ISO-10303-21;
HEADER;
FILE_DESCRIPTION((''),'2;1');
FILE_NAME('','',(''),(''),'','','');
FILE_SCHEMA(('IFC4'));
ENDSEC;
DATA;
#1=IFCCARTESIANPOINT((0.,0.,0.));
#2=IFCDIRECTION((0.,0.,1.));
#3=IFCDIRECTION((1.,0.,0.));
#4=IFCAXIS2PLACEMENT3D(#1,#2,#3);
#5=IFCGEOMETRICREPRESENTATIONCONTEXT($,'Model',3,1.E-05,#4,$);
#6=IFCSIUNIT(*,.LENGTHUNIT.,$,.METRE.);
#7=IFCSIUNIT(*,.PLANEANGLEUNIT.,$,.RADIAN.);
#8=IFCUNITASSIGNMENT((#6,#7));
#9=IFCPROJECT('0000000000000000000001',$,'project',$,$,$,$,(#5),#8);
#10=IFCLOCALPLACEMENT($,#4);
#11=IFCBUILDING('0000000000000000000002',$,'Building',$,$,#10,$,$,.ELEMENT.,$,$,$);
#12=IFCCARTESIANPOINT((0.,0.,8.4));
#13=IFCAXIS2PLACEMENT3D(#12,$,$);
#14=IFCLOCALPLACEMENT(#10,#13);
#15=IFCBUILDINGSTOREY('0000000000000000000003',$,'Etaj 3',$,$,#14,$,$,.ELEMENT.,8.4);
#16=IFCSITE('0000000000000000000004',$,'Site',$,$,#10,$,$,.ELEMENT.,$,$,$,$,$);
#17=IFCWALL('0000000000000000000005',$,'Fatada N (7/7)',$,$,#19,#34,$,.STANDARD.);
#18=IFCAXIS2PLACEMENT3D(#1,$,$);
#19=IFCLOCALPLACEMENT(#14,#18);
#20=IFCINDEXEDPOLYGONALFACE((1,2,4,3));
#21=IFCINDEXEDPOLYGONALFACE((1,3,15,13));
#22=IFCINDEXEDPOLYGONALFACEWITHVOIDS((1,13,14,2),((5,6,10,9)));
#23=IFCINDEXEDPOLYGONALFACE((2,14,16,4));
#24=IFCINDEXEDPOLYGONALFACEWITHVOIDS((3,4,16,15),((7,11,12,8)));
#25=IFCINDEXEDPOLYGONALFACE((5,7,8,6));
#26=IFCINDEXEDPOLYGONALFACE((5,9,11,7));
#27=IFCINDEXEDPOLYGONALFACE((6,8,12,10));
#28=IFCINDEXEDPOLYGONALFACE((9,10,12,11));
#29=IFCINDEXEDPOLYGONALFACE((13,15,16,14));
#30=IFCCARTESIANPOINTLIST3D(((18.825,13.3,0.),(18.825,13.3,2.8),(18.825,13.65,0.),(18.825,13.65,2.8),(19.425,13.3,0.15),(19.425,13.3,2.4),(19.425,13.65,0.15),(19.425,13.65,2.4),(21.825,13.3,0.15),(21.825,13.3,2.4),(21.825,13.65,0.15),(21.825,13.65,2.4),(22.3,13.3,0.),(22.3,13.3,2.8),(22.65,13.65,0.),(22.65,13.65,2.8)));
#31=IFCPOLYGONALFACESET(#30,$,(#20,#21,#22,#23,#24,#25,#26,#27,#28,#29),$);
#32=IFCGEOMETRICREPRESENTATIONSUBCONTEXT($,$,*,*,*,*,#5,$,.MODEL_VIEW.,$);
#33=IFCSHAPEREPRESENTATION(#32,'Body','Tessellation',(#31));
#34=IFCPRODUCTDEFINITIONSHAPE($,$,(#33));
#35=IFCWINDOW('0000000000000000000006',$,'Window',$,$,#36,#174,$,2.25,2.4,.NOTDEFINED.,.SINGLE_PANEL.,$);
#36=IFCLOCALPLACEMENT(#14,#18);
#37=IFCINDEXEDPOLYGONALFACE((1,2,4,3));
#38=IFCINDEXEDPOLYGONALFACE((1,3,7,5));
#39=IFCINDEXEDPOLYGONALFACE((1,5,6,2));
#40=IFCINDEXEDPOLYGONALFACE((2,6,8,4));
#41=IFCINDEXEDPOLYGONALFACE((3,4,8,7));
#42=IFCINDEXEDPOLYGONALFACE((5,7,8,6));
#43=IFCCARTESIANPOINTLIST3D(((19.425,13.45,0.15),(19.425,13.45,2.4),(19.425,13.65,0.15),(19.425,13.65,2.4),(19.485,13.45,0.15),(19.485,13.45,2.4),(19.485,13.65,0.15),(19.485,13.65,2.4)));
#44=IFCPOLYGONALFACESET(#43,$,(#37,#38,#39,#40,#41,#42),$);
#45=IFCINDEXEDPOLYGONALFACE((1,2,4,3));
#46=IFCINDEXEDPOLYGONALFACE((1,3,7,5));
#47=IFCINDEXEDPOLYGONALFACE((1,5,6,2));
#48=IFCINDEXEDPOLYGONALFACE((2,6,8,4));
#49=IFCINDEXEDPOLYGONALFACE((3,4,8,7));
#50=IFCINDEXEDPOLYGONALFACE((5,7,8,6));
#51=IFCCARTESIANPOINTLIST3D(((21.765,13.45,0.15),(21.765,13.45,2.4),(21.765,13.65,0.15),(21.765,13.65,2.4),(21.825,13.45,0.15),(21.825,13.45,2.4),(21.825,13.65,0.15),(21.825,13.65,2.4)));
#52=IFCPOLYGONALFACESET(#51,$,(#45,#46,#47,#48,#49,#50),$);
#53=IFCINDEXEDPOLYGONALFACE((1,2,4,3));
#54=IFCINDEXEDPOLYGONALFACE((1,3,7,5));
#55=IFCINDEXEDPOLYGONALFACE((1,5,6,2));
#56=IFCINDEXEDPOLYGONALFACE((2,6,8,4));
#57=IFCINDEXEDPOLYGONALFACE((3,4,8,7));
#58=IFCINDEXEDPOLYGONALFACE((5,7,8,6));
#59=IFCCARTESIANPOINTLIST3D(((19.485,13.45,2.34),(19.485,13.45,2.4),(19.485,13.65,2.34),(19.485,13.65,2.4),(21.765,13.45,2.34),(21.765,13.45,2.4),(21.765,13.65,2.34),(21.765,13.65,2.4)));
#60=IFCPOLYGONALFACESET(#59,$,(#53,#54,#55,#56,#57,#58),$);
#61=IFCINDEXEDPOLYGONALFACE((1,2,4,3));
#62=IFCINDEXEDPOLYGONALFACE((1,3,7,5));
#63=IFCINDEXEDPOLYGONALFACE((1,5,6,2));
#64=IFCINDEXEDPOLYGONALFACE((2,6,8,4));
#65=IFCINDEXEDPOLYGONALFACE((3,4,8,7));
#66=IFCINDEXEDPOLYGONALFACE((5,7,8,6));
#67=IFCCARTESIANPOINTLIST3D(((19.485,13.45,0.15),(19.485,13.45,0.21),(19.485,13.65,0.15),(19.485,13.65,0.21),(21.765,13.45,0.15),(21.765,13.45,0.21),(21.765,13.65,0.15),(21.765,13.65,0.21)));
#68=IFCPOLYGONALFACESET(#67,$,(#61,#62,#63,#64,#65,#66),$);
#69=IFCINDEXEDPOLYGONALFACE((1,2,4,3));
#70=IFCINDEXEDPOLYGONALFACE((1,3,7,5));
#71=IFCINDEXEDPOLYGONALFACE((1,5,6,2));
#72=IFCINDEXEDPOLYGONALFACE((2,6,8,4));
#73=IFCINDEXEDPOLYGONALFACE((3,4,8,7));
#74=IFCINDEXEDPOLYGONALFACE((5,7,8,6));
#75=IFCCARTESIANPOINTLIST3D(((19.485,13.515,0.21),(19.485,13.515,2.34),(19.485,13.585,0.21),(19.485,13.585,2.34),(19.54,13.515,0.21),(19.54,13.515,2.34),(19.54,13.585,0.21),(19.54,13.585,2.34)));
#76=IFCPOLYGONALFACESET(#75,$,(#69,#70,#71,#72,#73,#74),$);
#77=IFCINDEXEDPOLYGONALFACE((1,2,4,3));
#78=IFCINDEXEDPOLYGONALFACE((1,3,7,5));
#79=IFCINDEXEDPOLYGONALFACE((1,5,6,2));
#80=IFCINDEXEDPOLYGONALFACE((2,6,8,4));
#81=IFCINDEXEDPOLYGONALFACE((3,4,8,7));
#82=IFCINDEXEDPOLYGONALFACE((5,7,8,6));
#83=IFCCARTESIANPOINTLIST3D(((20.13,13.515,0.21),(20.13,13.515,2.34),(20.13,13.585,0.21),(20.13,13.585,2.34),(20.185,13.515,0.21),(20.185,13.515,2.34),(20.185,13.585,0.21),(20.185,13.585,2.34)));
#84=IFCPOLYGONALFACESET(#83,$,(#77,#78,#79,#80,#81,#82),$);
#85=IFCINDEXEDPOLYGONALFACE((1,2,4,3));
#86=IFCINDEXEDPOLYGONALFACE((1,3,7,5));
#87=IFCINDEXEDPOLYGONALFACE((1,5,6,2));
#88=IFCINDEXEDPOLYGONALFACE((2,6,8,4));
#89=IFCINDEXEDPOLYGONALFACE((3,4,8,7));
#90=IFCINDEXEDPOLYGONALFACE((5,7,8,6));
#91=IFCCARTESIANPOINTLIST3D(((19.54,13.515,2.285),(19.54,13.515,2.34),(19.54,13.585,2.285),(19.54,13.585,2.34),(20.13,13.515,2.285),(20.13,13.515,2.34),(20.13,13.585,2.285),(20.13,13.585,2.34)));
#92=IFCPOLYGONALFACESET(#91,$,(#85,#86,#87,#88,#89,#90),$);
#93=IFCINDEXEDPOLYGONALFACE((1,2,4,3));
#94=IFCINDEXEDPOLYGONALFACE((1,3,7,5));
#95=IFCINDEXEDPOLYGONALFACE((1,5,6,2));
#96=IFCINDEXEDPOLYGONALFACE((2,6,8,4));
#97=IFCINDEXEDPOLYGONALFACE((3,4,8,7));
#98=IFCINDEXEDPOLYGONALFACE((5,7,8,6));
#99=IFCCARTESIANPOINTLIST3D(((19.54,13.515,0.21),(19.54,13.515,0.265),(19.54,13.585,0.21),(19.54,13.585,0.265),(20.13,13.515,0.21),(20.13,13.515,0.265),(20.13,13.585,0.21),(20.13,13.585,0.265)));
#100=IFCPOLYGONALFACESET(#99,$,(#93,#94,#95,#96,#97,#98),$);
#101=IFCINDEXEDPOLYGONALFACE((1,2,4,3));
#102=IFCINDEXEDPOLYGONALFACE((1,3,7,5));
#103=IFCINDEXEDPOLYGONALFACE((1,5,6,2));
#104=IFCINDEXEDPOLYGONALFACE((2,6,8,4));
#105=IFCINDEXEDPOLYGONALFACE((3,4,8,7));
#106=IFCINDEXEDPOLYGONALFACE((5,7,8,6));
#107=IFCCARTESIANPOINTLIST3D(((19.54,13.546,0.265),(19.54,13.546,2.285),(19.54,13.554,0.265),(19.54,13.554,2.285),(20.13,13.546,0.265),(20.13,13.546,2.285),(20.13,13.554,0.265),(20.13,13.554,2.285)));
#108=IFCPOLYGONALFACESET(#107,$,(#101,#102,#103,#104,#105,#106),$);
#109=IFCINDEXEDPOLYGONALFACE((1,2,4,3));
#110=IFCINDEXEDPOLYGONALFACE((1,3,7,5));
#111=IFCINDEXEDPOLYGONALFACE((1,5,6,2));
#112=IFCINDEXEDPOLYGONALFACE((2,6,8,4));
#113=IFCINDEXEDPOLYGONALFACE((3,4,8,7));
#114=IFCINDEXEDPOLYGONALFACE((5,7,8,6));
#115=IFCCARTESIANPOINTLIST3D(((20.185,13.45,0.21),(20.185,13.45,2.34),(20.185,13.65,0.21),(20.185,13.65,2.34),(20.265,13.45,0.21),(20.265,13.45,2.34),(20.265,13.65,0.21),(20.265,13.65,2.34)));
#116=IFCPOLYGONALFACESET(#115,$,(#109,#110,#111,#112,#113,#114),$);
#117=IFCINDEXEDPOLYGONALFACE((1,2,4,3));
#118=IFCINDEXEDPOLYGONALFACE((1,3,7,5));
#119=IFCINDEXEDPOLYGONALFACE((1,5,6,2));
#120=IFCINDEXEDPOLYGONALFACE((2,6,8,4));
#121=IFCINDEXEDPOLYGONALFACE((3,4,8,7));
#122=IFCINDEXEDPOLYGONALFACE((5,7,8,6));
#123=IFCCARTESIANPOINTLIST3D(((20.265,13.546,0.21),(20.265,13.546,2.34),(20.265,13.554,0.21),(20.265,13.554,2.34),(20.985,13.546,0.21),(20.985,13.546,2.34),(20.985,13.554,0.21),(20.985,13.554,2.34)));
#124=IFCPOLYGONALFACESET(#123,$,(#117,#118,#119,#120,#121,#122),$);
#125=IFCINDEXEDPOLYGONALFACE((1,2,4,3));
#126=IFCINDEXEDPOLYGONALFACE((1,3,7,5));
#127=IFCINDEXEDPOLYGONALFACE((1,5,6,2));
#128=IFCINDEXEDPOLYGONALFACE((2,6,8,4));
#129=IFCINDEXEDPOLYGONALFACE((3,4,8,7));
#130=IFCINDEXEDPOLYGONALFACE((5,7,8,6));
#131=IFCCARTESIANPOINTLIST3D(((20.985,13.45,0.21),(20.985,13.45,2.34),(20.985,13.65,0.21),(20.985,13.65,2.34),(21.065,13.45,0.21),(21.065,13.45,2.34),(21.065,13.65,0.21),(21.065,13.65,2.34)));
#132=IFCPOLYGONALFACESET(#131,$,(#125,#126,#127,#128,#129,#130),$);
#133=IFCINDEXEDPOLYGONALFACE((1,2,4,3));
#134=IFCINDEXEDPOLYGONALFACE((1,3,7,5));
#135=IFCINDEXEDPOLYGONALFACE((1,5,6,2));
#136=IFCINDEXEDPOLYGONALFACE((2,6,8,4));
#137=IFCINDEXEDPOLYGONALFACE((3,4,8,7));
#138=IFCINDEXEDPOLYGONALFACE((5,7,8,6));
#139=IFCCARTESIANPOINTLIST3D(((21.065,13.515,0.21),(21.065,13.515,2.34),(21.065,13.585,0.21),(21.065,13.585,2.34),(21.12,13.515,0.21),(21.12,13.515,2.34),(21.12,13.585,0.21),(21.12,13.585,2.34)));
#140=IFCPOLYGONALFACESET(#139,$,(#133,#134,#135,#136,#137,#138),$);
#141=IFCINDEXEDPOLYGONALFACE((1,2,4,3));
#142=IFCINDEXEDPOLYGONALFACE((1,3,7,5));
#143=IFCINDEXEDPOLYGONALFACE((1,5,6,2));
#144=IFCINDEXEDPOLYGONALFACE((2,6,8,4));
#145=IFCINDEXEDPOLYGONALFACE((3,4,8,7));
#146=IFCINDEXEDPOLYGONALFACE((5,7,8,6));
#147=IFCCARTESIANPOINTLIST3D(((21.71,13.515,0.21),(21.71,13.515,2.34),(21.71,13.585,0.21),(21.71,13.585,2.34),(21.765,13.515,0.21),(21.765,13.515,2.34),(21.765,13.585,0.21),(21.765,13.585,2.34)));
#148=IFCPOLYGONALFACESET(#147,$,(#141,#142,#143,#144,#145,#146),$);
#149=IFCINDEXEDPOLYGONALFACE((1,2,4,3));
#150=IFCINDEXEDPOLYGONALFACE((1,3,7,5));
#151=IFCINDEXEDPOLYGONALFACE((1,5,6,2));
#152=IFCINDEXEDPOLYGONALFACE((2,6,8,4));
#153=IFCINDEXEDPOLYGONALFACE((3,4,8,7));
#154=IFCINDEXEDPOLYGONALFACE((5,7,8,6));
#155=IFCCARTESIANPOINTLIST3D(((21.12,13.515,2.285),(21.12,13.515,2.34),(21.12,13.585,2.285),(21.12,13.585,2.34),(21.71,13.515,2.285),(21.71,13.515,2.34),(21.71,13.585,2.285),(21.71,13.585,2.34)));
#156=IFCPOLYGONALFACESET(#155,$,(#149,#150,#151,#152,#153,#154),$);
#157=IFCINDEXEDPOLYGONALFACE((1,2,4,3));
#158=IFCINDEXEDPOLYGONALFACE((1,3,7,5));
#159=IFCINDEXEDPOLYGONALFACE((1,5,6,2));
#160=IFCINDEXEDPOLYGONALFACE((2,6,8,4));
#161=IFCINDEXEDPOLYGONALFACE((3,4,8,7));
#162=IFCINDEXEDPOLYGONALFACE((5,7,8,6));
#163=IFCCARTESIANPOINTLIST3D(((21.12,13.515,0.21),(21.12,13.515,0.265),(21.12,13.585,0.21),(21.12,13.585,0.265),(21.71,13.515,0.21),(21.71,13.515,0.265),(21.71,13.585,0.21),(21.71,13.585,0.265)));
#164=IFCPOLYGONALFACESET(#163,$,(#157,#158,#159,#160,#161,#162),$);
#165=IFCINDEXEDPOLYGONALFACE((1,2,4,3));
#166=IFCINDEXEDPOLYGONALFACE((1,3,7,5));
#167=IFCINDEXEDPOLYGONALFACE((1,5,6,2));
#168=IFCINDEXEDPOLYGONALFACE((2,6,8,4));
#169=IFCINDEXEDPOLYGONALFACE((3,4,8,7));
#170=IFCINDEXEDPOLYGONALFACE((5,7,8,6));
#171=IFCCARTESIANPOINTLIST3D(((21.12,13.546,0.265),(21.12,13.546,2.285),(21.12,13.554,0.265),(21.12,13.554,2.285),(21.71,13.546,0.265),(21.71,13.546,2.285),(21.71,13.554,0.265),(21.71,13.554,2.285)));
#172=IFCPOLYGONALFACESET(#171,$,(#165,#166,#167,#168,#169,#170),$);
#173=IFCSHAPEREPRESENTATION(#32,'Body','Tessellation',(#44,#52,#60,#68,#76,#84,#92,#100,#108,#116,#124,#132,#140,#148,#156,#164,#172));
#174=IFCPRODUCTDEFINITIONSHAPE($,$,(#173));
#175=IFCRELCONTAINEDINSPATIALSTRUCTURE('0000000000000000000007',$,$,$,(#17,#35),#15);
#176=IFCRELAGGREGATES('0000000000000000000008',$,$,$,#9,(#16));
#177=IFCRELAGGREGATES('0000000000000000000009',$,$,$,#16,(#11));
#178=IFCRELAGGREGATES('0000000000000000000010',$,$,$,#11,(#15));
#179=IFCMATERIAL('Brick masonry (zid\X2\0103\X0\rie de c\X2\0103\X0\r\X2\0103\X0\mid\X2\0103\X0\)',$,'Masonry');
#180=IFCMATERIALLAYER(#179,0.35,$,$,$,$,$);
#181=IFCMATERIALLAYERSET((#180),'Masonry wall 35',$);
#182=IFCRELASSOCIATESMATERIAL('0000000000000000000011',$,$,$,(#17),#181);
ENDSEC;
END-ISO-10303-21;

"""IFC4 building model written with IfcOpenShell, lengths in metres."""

from ifc_helpers import new_model, si_unit, frame, frame_2d, origin, origin_with_axes, origin_2d, place, context, subcontext, project, spatial, rectangle, extrude, clip, halfspace, material, layer, layer_set, layer_usage, element, fill, save


model = new_model("IFC4")

# Units and contexts
model_context = context("Model", 3, precision=1e-05, world=origin_with_axes())
sub_context = subcontext(model_context, None, None, "MODEL_VIEW")
ifc_project = project(units=[si_unit("LENGTHUNIT", "METRE"), si_unit("PLANEANGLEUNIT", "RADIAN")], contexts=[model_context])

# Site, building, storey
placement = place(None, origin_with_axes())
site = spatial("IfcSite", under=ifc_project, at=placement, Name="Site", CompositionType="ELEMENT")
building = spatial("IfcBuilding", under=site, at=placement, Name="Building", CompositionType="ELEMENT")
storey_placement = place(placement, frame((0.0, 0.0, 8.4)))
storey = spatial("IfcBuildingStorey", under=building, at=storey_placement, Name="Etaj 3", CompositionType="ELEMENT", Elevation=8.4)

# Wall, opening, window
ifc_material_1 = material(Name="Brick masonry (zidărie de cărămidă)", Category="Masonry")
ifc_layer_1 = layer(ifc_material_1, 0.35)
ifc_layer_set_1 = layer_set([ifc_layer_1], Name="Masonry wall 35")
ifc_layer_usage_1 = layer_usage(ifc_layer_set_1, "AXIS2", "POSITIVE", -0.175)
wall_1_placement = place(storey_placement, frame((18.825, 13.475, 0.0), x_axis=(1.0, 0.0, 0.0)))
wall_1 = element("IfcWall", 1, at=wall_1_placement, inside=storey, material=ifc_layer_usage_1, Name="Fatada N (7/7)", PredefinedType="STANDARD", context=sub_context, shape_type="CSG", body=[
    clip(extrude(rectangle(XDim=3.825, YDim=0.35, at=frame_2d((1.9125, 0.0))), origin(), (0.0, 0.0, 1.0), 2.8), halfspace(frame((3.65, 0.0, 0.0), z_axis=(0.707107, -0.707107, 0.0)), False)),
])
opening_1_placement = place(wall_1_placement, frame((1.8, 0.225, 0.15), z_axis=(0.0, -1.0, 0.0), x_axis=(1.0, 0.0, 0.0)))
opening_1 = element("IfcOpeningElement", 2, at=opening_1_placement, cuts=wall_1, PredefinedType="OPENING", context=sub_context, shape_type="SweptSolid", body=[
    extrude(rectangle(XDim=2.4, YDim=2.25, at=frame_2d((0.0, 1.125))), origin(), (0.0, 0.0, 1.0), 0.45),
])
window_1_placement = place(wall_1_placement, frame((1.8, 0.175, 0.15), z_axis=(0.0, -1.0, 0.0), x_axis=(1.0, 0.0, 0.0)))
window_1 = element("IfcWindow", 3, at=window_1_placement, inside=storey, Name="Window", OverallHeight=2.25, OverallWidth=2.4, PartitioningType="SINGLE_PANEL", PredefinedType="NOTDEFINED", context=sub_context, shape_type="SweptSolid", body=[
    extrude(rectangle(XDim=0.06, YDim=2.25, at=origin_2d()), frame((-1.17, 1.125, 0.0)), (0.0, 0.0, 1.0), 0.2),
    extrude(rectangle(XDim=0.06, YDim=2.25, at=origin_2d()), frame((1.17, 1.125, 0.0)), (0.0, 0.0, 1.0), 0.2),
    extrude(rectangle(XDim=2.28, YDim=0.06, at=origin_2d()), frame((0.0, 2.22, 0.0)), (0.0, 0.0, 1.0), 0.2),
    extrude(rectangle(XDim=2.28, YDim=0.06, at=origin_2d()), frame((0.0, 0.03, 0.0)), (0.0, 0.0, 1.0), 0.2),
    extrude(rectangle(XDim=0.055, YDim=2.13, at=origin_2d()), frame((-1.1125, 1.125, 0.065)), (0.0, 0.0, 1.0), 0.07),
    extrude(rectangle(XDim=0.055, YDim=2.13, at=origin_2d()), frame((-0.4675, 1.125, 0.065)), (0.0, 0.0, 1.0), 0.07),
    extrude(rectangle(XDim=0.59, YDim=0.055, at=origin_2d()), frame((-0.79, 2.1625, 0.065)), (0.0, 0.0, 1.0), 0.07),
    extrude(rectangle(XDim=0.59, YDim=0.055, at=origin_2d()), frame((-0.79, 0.0875, 0.065)), (0.0, 0.0, 1.0), 0.07),
    extrude(rectangle(XDim=0.59, YDim=2.02, at=origin_2d()), frame((-0.79, 1.125, 0.096)), (0.0, 0.0, 1.0), 0.008),
    extrude(rectangle(XDim=0.08, YDim=2.13, at=origin_2d()), frame((-0.4, 1.125, 0.0)), (0.0, 0.0, 1.0), 0.2),
    extrude(rectangle(XDim=0.72, YDim=2.13, at=origin_2d()), frame((0.0, 1.125, 0.096)), (0.0, 0.0, 1.0), 0.008),
    extrude(rectangle(XDim=0.08, YDim=2.13, at=origin_2d()), frame((0.4, 1.125, 0.0)), (0.0, 0.0, 1.0), 0.2),
    extrude(rectangle(XDim=0.055, YDim=2.13, at=origin_2d()), frame((0.4675, 1.125, 0.065)), (0.0, 0.0, 1.0), 0.07),
    extrude(rectangle(XDim=0.055, YDim=2.13, at=origin_2d()), frame((1.1125, 1.125, 0.065)), (0.0, 0.0, 1.0), 0.07),
    extrude(rectangle(XDim=0.59, YDim=0.055, at=origin_2d()), frame((0.79, 2.1625, 0.065)), (0.0, 0.0, 1.0), 0.07),
    extrude(rectangle(XDim=0.59, YDim=0.055, at=origin_2d()), frame((0.79, 0.0875, 0.065)), (0.0, 0.0, 1.0), 0.07),
    extrude(rectangle(XDim=0.59, YDim=2.02, at=origin_2d()), frame((0.79, 1.125, 0.096)), (0.0, 0.0, 1.0), 0.008),
])
fill(opening_1, window_1)

save(model, "model.ifc")
